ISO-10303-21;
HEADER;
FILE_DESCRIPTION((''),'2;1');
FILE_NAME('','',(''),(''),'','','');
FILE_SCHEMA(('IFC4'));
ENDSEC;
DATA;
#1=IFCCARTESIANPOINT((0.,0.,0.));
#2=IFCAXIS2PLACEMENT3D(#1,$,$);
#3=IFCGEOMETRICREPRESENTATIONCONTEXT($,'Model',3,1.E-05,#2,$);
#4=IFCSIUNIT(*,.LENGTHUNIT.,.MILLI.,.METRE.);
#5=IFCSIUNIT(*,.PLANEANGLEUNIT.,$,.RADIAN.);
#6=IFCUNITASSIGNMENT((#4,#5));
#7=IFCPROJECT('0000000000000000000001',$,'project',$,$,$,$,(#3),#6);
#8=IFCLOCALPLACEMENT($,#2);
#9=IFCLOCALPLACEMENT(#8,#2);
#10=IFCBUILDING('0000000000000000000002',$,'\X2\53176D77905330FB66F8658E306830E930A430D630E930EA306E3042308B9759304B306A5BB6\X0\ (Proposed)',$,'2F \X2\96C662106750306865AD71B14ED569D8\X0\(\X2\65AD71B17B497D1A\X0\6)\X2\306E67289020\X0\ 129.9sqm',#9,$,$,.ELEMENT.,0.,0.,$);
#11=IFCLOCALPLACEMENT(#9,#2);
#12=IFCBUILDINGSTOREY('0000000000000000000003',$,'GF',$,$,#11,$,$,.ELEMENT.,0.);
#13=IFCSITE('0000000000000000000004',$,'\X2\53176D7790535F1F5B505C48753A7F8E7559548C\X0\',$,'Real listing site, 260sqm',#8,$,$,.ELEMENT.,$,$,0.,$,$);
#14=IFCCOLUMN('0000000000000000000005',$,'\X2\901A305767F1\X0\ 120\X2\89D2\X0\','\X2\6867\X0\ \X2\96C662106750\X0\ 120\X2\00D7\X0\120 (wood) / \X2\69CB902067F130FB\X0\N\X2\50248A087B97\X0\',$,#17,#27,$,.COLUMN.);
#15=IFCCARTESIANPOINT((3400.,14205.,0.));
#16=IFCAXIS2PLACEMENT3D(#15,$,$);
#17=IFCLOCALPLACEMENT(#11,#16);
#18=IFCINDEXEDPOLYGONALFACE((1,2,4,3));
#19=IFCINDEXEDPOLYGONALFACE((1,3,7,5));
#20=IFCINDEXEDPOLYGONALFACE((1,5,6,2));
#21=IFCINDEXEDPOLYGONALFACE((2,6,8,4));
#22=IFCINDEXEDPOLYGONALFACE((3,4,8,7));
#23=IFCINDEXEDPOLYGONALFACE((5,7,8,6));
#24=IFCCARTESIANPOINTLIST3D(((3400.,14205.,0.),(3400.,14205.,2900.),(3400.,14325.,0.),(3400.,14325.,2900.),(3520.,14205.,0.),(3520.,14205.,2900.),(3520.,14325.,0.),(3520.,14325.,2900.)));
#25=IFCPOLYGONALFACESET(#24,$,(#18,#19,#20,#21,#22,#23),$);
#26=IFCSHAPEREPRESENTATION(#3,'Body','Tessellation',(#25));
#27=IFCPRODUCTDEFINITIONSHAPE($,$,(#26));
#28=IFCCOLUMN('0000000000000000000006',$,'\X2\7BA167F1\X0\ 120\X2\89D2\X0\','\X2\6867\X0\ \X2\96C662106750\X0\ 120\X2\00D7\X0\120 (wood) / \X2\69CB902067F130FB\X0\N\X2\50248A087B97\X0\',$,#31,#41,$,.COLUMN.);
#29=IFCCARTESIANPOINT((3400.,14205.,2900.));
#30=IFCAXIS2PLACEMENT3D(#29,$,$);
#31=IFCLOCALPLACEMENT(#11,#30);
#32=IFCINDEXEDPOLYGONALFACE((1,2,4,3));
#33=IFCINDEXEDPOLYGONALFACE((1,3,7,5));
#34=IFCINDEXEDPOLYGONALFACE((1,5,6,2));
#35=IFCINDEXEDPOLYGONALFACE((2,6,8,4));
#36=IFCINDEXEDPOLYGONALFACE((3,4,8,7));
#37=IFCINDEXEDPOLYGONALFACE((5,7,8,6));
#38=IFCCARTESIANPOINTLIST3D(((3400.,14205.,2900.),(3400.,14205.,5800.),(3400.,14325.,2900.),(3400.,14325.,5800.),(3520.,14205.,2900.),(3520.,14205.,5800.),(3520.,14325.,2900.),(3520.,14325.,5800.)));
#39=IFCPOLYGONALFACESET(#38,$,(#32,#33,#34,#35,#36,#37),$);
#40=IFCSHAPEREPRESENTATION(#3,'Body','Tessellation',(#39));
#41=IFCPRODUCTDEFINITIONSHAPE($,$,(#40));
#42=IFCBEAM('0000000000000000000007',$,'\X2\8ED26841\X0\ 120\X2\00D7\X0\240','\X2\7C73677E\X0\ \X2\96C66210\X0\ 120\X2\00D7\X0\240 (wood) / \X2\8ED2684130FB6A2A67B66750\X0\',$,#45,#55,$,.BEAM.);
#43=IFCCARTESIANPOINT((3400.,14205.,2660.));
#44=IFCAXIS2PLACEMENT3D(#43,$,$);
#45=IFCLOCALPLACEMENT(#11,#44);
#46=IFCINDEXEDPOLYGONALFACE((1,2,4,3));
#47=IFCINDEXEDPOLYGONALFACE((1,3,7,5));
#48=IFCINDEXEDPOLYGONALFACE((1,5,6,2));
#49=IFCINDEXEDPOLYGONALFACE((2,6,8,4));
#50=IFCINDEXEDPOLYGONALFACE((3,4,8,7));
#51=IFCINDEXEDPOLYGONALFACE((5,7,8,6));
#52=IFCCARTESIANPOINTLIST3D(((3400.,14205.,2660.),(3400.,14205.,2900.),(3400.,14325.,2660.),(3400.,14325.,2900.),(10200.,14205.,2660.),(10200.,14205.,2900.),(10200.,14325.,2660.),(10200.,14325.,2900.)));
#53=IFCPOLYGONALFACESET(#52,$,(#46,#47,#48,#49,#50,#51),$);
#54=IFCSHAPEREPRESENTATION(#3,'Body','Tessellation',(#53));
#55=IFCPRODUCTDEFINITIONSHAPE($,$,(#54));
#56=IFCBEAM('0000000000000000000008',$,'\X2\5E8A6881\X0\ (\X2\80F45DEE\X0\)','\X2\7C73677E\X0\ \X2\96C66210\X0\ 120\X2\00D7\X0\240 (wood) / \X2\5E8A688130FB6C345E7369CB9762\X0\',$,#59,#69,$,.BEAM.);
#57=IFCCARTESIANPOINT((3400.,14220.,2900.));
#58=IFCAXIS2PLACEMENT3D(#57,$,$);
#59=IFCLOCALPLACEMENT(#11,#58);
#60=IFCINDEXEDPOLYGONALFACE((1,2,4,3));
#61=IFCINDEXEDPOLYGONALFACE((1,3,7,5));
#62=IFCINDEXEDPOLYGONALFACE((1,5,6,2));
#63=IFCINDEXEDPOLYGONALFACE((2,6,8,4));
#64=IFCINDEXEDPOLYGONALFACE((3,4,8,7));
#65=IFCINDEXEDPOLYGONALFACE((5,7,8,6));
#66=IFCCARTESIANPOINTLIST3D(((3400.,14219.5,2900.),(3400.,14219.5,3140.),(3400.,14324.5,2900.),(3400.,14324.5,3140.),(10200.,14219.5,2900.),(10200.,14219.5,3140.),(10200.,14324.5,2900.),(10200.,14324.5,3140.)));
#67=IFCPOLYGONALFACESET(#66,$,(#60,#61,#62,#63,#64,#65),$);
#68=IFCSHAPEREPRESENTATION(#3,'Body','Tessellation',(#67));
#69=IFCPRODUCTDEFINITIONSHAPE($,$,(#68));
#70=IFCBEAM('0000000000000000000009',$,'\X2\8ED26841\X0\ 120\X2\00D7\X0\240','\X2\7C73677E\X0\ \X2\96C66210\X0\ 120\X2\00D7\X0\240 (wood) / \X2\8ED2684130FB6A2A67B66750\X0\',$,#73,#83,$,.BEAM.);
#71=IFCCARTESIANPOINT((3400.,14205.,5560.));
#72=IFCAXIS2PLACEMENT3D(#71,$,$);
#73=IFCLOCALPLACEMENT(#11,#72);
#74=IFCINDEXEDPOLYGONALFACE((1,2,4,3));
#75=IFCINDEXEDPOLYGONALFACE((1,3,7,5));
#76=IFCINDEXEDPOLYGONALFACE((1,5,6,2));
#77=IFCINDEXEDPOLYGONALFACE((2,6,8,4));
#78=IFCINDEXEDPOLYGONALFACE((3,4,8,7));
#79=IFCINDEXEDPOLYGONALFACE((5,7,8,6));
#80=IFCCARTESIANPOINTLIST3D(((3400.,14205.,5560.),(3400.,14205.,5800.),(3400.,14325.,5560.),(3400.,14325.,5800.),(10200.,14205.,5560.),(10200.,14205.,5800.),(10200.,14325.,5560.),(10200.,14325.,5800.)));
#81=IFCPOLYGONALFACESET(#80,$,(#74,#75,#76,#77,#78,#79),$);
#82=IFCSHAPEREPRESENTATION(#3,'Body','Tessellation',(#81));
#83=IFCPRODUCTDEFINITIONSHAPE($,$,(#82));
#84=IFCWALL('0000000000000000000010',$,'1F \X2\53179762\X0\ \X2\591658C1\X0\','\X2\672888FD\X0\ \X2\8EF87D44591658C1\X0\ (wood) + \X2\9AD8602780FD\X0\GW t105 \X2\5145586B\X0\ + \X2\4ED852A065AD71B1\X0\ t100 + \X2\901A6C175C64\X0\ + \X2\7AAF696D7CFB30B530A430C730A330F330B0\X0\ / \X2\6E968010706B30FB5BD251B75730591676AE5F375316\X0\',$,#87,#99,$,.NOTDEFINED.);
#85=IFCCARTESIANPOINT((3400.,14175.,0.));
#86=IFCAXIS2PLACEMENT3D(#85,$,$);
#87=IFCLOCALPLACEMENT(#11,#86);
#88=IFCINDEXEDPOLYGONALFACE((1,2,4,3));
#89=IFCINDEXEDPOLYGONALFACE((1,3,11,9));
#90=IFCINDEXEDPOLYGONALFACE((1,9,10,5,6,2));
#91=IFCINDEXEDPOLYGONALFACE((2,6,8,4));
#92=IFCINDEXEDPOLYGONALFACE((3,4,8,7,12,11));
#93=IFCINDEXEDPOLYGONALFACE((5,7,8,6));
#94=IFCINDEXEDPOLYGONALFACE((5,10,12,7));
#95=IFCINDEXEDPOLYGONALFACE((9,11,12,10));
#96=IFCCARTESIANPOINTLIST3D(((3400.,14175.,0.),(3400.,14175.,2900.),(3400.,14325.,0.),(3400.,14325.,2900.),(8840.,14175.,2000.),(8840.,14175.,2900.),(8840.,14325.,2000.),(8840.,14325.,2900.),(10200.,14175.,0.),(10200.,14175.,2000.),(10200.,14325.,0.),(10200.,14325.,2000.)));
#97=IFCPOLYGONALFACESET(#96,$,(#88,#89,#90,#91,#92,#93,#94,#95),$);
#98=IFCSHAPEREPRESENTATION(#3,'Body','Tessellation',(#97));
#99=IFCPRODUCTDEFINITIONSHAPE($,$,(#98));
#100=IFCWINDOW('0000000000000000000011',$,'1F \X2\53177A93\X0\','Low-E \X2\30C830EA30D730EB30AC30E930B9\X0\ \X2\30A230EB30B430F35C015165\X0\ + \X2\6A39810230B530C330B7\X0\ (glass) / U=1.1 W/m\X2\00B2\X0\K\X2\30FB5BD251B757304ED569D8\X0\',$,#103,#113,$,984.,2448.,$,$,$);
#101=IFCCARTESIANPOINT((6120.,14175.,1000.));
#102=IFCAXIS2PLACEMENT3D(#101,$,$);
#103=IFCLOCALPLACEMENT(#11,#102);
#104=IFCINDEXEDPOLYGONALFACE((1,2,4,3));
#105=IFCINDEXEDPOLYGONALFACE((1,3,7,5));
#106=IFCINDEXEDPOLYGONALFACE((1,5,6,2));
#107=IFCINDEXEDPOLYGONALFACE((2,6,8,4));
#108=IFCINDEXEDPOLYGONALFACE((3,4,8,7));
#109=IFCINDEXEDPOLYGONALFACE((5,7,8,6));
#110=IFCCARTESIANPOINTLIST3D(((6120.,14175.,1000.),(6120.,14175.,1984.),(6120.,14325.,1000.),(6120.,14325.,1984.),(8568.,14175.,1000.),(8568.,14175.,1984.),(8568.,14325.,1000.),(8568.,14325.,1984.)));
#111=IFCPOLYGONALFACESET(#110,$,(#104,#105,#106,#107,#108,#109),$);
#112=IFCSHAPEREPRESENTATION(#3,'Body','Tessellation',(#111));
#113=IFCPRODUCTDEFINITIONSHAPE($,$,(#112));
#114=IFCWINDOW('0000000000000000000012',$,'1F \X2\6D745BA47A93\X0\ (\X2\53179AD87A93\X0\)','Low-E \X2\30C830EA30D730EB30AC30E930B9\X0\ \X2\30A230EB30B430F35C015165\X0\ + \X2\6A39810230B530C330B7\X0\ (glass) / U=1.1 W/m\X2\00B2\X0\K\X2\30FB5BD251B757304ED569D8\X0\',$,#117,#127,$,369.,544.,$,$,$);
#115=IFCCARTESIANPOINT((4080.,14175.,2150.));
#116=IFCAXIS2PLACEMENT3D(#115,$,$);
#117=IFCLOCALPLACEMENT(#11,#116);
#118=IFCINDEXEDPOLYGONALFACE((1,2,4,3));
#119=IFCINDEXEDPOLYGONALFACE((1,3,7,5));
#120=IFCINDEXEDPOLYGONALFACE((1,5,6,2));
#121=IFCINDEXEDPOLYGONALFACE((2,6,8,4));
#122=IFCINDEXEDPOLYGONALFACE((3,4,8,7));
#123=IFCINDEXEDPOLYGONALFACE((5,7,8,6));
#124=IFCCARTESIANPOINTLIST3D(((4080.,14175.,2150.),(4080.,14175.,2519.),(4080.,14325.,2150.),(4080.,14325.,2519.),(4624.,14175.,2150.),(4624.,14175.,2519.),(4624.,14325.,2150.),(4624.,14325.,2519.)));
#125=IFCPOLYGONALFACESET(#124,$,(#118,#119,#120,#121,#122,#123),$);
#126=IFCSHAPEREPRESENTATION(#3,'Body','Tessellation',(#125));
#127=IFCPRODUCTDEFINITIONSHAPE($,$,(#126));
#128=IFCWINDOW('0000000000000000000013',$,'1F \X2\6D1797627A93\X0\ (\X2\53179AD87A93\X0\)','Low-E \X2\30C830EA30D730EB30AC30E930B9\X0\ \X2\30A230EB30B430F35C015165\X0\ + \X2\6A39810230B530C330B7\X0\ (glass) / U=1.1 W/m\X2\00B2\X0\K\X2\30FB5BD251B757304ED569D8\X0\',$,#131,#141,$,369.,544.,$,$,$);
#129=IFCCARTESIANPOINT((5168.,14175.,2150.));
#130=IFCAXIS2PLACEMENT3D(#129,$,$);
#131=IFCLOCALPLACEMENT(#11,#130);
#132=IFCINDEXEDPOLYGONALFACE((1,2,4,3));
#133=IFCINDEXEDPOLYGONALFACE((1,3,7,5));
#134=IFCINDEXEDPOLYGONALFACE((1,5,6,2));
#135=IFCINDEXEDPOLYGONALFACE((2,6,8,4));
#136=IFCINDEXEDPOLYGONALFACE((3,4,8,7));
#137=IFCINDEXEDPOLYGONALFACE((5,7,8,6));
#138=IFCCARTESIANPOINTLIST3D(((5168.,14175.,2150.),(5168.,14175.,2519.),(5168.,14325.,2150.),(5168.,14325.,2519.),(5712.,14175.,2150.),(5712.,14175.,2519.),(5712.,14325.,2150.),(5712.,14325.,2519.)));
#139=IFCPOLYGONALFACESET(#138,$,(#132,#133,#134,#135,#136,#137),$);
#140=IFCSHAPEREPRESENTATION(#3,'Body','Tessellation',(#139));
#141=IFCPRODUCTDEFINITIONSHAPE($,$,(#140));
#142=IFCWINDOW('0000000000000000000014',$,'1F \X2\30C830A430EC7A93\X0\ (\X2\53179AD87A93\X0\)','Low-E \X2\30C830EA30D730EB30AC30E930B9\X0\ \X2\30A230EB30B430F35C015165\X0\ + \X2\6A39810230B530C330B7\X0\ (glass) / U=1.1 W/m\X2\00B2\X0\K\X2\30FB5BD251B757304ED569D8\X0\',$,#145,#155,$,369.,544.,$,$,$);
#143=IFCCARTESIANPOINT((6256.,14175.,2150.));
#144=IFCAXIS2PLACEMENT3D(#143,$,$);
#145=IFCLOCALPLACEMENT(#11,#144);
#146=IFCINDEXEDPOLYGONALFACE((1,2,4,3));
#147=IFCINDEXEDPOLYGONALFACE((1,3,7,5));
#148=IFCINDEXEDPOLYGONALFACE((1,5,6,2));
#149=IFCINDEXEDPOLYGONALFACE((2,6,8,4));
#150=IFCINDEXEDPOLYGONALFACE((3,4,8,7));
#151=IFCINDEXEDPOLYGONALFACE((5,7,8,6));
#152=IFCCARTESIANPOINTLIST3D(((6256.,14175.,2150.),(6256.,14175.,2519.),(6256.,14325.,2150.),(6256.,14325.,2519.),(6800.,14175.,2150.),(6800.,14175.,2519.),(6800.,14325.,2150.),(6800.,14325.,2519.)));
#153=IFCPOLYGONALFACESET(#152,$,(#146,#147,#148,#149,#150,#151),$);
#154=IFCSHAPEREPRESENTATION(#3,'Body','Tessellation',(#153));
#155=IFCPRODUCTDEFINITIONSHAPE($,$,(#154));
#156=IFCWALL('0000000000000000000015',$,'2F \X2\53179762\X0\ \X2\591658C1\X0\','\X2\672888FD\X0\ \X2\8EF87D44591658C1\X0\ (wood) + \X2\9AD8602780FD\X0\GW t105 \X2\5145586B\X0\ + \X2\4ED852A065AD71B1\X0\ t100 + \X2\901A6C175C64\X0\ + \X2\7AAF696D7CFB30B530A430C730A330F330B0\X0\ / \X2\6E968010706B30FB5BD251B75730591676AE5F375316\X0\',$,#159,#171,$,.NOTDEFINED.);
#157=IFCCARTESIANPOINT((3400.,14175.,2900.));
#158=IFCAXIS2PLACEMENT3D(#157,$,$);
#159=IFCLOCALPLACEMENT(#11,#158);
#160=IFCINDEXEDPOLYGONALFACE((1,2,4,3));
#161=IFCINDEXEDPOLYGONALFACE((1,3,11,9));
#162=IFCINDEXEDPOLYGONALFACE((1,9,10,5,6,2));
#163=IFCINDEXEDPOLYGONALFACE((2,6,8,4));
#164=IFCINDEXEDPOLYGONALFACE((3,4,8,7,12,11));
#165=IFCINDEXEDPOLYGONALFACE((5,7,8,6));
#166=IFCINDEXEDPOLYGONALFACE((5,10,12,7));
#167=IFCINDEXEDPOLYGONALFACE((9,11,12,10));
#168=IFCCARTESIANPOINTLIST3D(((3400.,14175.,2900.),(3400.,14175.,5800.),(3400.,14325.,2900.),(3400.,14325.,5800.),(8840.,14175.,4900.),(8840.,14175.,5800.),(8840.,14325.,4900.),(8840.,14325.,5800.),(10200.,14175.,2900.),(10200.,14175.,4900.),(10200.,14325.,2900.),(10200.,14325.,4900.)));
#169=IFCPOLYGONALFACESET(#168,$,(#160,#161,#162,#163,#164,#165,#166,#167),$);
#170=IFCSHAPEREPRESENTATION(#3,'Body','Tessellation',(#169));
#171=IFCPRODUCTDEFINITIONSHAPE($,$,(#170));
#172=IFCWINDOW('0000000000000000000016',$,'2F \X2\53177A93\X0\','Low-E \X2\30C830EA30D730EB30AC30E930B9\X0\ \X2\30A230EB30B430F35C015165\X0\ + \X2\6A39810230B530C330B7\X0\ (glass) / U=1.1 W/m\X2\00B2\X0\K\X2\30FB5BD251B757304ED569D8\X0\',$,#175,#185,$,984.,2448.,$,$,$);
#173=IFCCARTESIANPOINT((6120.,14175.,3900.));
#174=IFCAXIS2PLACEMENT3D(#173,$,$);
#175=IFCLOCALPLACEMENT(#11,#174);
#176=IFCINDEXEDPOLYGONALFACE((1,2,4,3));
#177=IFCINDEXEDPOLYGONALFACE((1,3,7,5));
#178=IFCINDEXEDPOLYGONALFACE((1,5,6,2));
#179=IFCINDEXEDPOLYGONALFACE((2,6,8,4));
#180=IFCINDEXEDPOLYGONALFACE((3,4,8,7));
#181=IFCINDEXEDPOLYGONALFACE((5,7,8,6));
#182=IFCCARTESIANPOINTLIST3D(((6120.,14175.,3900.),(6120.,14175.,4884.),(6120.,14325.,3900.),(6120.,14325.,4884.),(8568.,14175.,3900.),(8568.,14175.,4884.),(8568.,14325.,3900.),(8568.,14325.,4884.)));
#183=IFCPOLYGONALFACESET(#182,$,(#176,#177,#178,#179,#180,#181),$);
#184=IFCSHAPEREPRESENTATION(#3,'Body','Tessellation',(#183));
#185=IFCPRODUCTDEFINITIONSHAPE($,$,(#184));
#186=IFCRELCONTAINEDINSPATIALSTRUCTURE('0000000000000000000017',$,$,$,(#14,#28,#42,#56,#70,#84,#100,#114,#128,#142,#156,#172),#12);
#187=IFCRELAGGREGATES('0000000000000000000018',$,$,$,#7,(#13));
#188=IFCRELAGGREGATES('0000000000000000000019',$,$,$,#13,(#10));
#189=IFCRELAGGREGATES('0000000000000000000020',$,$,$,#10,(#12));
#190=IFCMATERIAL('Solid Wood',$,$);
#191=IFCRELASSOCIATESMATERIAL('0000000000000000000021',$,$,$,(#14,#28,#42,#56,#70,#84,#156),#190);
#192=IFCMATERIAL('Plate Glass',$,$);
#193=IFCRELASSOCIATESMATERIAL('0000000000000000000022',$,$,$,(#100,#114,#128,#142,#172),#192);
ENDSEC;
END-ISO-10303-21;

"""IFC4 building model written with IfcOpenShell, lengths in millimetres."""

from ifc_helpers import new_model, si_unit, frame, frame_2d, origin, place, context, project, spatial, rectangle, extrude, material, element, fill, save


model = new_model("IFC4")

# Units and contexts
model_context = context("Model", 3, precision=1e-05, world=origin())
ifc_project = project(units=[si_unit("LENGTHUNIT", "METRE", prefix="MILLI"), si_unit("PLANEANGLEUNIT", "RADIAN")], contexts=[model_context])

# Site, building, storey
site_placement = place(None, origin())
site = spatial("IfcSite", under=ifc_project, at=site_placement, Name="北海道弟子屈町美留和", ObjectType="Real listing site, 260sqm", CompositionType="ELEMENT", RefElevation=0.0)
building_placement = place(site_placement, origin())
building = spatial("IfcBuilding", under=site, at=building_placement, Name="北海道・書斎とライブラリのある静かな家 (Proposed)", ObjectType="2F 集成材と断熱仕様(断熱等級6)の木造 129.9sqm", CompositionType="ELEMENT", ElevationOfRefHeight=0.0, ElevationOfTerrain=0.0)
storey_placement = place(building_placement, origin())
storey = spatial("IfcBuildingStorey", under=building, at=storey_placement, Name="GF", CompositionType="ELEMENT", Elevation=0.0)

# Columns
ifc_material_1 = material(Name="Solid Wood")
column_1_placement = place(storey_placement, frame((3400.0, 14205.0, 0.0)))
element("IfcColumn", 1, at=column_1_placement, inside=storey, material=ifc_material_1, Name="通し柱 120角", Description="桧 集成材 120×120 (wood) / 構造柱・N値計算", PredefinedType="COLUMN", context=model_context, shape_type="SweptSolid", body=[
    extrude(rectangle(XDim=120.0, YDim=120.0, at=frame_2d((60.0, 60.0))), frame((3400.0, 14205.0, 0.0)), (0.0, 0.0, 1.0), 2900.0),
])
column_2_placement = place(storey_placement, frame((3400.0, 14205.0, 2900.0)))
element("IfcColumn", 2, at=column_2_placement, inside=storey, material=ifc_material_1, Name="管柱 120角", Description="桧 集成材 120×120 (wood) / 構造柱・N値計算", PredefinedType="COLUMN", context=model_context, shape_type="SweptSolid", body=[
    extrude(rectangle(XDim=120.0, YDim=120.0, at=frame_2d((60.0, 60.0))), frame((3400.0, 14205.0, 2900.0)), (0.0, 0.0, 1.0), 2900.0),
])

# Beams
beam_1_placement = place(storey_placement, frame((3400.0, 14205.0, 2660.0)))
element("IfcBeam", 3, at=beam_1_placement, inside=storey, material=ifc_material_1, Name="軒桁 120×240", Description="米松 集成 120×240 (wood) / 軒桁・横架材", PredefinedType="BEAM", context=model_context, shape_type="SweptSolid", body=[
    extrude(rectangle(XDim=6800.0, YDim=120.0, at=frame_2d((3400.0, 60.0))), frame((3400.0, 14205.0, 2660.0)), (0.0, 0.0, 1.0), 240.0),
])
beam_2_placement = place(storey_placement, frame((3400.0, 14220.0, 2900.0)))
element("IfcBeam", 4, at=beam_2_placement, inside=storey, material=ifc_material_1, Name="床梁 (胴差)", Description="米松 集成 120×240 (wood) / 床梁・水平構面", PredefinedType="BEAM", context=model_context, shape_type="SweptSolid", body=[
    extrude(rectangle(XDim=6800.0, YDim=105.0, at=frame_2d((3400.0, 52.0))), frame((3400.0, 14220.0, 2900.0)), (0.0, 0.0, 1.0), 240.0),
])
beam_3_placement = place(storey_placement, frame((3400.0, 14205.0, 5560.0)))
element("IfcBeam", 5, at=beam_3_placement, inside=storey, material=ifc_material_1, Name="軒桁 120×240", Description="米松 集成 120×240 (wood) / 軒桁・横架材", PredefinedType="BEAM", context=model_context, shape_type="SweptSolid", body=[
    extrude(rectangle(XDim=6800.0, YDim=120.0, at=frame_2d((3400.0, 60.0))), frame((3400.0, 14205.0, 5560.0)), (0.0, 0.0, 1.0), 240.0),
])

# Wall, openings, windows
wall_1_placement = place(storey_placement, frame((3400.0, 14175.0, 0.0)))
wall_1 = element("IfcWall", 6, at=wall_1_placement, inside=storey, material=ifc_material_1, Name="1F 北面 外壁", Description="木製 軸組外壁 (wood) + 高性能GW t105 充填 + 付加断熱 t100 + 通気層 + 窯業系サイディング / 準耐火・寒冷地外皮強化", PredefinedType="NOTDEFINED", context=model_context, shape_type="SweptSolid", body=[
    extrude(rectangle(XDim=6800.0, YDim=150.0, at=frame_2d((3400.0, 75.0))), frame((3400.0, 14175.0, 0.0)), (0.0, 0.0, 1.0), 2900.0),
])
opening_1_placement = place(storey_placement, frame((6120.0, 14175.0, 1000.0)))
opening_1 = element("IfcOpeningElement", 7, at=opening_1_placement, cuts=wall_1, PredefinedType="NOTDEFINED", context=model_context, shape_type="SweptSolid", body=[
    extrude(rectangle(XDim=2448.0, YDim=150.0, at=frame_2d((1224.0, 75.0))), frame((6120.0, 14175.0, 1000.0)), (0.0, 0.0, 1.0), 984.0),
])
opening_2_placement = place(storey_placement, frame((4080.0, 14175.0, 2150.0)))
opening_2 = element("IfcOpeningElement", 8, at=opening_2_placement, cuts=wall_1, PredefinedType="NOTDEFINED", context=model_context, shape_type="SweptSolid", body=[
    extrude(rectangle(XDim=544.0, YDim=150.0, at=frame_2d((272.0, 75.0))), frame((4080.0, 14175.0, 2150.0)), (0.0, 0.0, 1.0), 369.0),
])
opening_3_placement = place(storey_placement, frame((5168.0, 14175.0, 2150.0)))
opening_3 = element("IfcOpeningElement", 9, at=opening_3_placement, cuts=wall_1, PredefinedType="NOTDEFINED", context=model_context, shape_type="SweptSolid", body=[
    extrude(rectangle(XDim=544.0, YDim=150.0, at=frame_2d((272.0, 75.0))), frame((5168.0, 14175.0, 2150.0)), (0.0, 0.0, 1.0), 369.0),
])
opening_4_placement = place(storey_placement, frame((6256.0, 14175.0, 2150.0)))
opening_4 = element("IfcOpeningElement", 10, at=opening_4_placement, cuts=wall_1, PredefinedType="NOTDEFINED", context=model_context, shape_type="SweptSolid", body=[
    extrude(rectangle(XDim=544.0, YDim=150.0, at=frame_2d((272.0, 75.0))), frame((6256.0, 14175.0, 2150.0)), (0.0, 0.0, 1.0), 369.0),
])
ifc_material_2 = material(Name="Plate Glass")
window_1_placement = place(storey_placement, frame((6120.0, 14175.0, 1000.0)))
window_1 = element("IfcWindow", 11, at=window_1_placement, inside=storey, material=ifc_material_2, Name="1F 北窓", Description="Low-E トリプルガラス アルゴン封入 + 樹脂サッシ (glass) / U=1.1 W/m²K・寒冷地仕様", OverallHeight=984.0, OverallWidth=2448.0, context=model_context, shape_type="SweptSolid", body=[
    extrude(rectangle(XDim=2448.0, YDim=150.0, at=frame_2d((1224.0, 75.0))), frame((6120.0, 14175.0, 1000.0)), (0.0, 0.0, 1.0), 984.0),
])
fill(opening_1, window_1)
window_2_placement = place(storey_placement, frame((4080.0, 14175.0, 2150.0)))
window_2 = element("IfcWindow", 12, at=window_2_placement, inside=storey, material=ifc_material_2, Name="1F 浴室窓 (北高窓)", Description="Low-E トリプルガラス アルゴン封入 + 樹脂サッシ (glass) / U=1.1 W/m²K・寒冷地仕様", OverallHeight=369.0, OverallWidth=544.0, context=model_context, shape_type="SweptSolid", body=[
    extrude(rectangle(XDim=544.0, YDim=150.0, at=frame_2d((272.0, 75.0))), frame((4080.0, 14175.0, 2150.0)), (0.0, 0.0, 1.0), 369.0),
])
fill(opening_2, window_2)
window_3_placement = place(storey_placement, frame((5168.0, 14175.0, 2150.0)))
window_3 = element("IfcWindow", 13, at=window_3_placement, inside=storey, material=ifc_material_2, Name="1F 洗面窓 (北高窓)", Description="Low-E トリプルガラス アルゴン封入 + 樹脂サッシ (glass) / U=1.1 W/m²K・寒冷地仕様", OverallHeight=369.0, OverallWidth=544.0, context=model_context, shape_type="SweptSolid", body=[
    extrude(rectangle(XDim=544.0, YDim=150.0, at=frame_2d((272.0, 75.0))), frame((5168.0, 14175.0, 2150.0)), (0.0, 0.0, 1.0), 369.0),
])
fill(opening_3, window_3)
window_4_placement = place(storey_placement, frame((6256.0, 14175.0, 2150.0)))
window_4 = element("IfcWindow", 14, at=window_4_placement, inside=storey, material=ifc_material_2, Name="1F トイレ窓 (北高窓)", Description="Low-E トリプルガラス アルゴン封入 + 樹脂サッシ (glass) / U=1.1 W/m²K・寒冷地仕様", OverallHeight=369.0, OverallWidth=544.0, context=model_context, shape_type="SweptSolid", body=[
    extrude(rectangle(XDim=544.0, YDim=150.0, at=frame_2d((272.0, 75.0))), frame((6256.0, 14175.0, 2150.0)), (0.0, 0.0, 1.0), 369.0),
])
fill(opening_4, window_4)

# Wall, opening, window
wall_2_placement = place(storey_placement, frame((3400.0, 14175.0, 2900.0)))
wall_2 = element("IfcWall", 15, at=wall_2_placement, inside=storey, material=ifc_material_1, Name="2F 北面 外壁", Description="木製 軸組外壁 (wood) + 高性能GW t105 充填 + 付加断熱 t100 + 通気層 + 窯業系サイディング / 準耐火・寒冷地外皮強化", PredefinedType="NOTDEFINED", context=model_context, shape_type="SweptSolid", body=[
    extrude(rectangle(XDim=6800.0, YDim=150.0, at=frame_2d((3400.0, 75.0))), frame((3400.0, 14175.0, 2900.0)), (0.0, 0.0, 1.0), 2900.0),
])
opening_5_placement = place(storey_placement, frame((6120.0, 14175.0, 3900.0)))
opening_5 = element("IfcOpeningElement", 16, at=opening_5_placement, cuts=wall_2, PredefinedType="NOTDEFINED", context=model_context, shape_type="SweptSolid", body=[
    extrude(rectangle(XDim=2448.0, YDim=150.0, at=frame_2d((1224.0, 75.0))), frame((6120.0, 14175.0, 3900.0)), (0.0, 0.0, 1.0), 984.0),
])
window_5_placement = place(storey_placement, frame((6120.0, 14175.0, 3900.0)))
window_5 = element("IfcWindow", 17, at=window_5_placement, inside=storey, material=ifc_material_2, Name="2F 北窓", Description="Low-E トリプルガラス アルゴン封入 + 樹脂サッシ (glass) / U=1.1 W/m²K・寒冷地仕様", OverallHeight=984.0, OverallWidth=2448.0, context=model_context, shape_type="SweptSolid", body=[
    extrude(rectangle(XDim=2448.0, YDim=150.0, at=frame_2d((1224.0, 75.0))), frame((6120.0, 14175.0, 3900.0)), (0.0, 0.0, 1.0), 984.0),
])
fill(opening_5, window_5)

save(model, "model.ifc")
